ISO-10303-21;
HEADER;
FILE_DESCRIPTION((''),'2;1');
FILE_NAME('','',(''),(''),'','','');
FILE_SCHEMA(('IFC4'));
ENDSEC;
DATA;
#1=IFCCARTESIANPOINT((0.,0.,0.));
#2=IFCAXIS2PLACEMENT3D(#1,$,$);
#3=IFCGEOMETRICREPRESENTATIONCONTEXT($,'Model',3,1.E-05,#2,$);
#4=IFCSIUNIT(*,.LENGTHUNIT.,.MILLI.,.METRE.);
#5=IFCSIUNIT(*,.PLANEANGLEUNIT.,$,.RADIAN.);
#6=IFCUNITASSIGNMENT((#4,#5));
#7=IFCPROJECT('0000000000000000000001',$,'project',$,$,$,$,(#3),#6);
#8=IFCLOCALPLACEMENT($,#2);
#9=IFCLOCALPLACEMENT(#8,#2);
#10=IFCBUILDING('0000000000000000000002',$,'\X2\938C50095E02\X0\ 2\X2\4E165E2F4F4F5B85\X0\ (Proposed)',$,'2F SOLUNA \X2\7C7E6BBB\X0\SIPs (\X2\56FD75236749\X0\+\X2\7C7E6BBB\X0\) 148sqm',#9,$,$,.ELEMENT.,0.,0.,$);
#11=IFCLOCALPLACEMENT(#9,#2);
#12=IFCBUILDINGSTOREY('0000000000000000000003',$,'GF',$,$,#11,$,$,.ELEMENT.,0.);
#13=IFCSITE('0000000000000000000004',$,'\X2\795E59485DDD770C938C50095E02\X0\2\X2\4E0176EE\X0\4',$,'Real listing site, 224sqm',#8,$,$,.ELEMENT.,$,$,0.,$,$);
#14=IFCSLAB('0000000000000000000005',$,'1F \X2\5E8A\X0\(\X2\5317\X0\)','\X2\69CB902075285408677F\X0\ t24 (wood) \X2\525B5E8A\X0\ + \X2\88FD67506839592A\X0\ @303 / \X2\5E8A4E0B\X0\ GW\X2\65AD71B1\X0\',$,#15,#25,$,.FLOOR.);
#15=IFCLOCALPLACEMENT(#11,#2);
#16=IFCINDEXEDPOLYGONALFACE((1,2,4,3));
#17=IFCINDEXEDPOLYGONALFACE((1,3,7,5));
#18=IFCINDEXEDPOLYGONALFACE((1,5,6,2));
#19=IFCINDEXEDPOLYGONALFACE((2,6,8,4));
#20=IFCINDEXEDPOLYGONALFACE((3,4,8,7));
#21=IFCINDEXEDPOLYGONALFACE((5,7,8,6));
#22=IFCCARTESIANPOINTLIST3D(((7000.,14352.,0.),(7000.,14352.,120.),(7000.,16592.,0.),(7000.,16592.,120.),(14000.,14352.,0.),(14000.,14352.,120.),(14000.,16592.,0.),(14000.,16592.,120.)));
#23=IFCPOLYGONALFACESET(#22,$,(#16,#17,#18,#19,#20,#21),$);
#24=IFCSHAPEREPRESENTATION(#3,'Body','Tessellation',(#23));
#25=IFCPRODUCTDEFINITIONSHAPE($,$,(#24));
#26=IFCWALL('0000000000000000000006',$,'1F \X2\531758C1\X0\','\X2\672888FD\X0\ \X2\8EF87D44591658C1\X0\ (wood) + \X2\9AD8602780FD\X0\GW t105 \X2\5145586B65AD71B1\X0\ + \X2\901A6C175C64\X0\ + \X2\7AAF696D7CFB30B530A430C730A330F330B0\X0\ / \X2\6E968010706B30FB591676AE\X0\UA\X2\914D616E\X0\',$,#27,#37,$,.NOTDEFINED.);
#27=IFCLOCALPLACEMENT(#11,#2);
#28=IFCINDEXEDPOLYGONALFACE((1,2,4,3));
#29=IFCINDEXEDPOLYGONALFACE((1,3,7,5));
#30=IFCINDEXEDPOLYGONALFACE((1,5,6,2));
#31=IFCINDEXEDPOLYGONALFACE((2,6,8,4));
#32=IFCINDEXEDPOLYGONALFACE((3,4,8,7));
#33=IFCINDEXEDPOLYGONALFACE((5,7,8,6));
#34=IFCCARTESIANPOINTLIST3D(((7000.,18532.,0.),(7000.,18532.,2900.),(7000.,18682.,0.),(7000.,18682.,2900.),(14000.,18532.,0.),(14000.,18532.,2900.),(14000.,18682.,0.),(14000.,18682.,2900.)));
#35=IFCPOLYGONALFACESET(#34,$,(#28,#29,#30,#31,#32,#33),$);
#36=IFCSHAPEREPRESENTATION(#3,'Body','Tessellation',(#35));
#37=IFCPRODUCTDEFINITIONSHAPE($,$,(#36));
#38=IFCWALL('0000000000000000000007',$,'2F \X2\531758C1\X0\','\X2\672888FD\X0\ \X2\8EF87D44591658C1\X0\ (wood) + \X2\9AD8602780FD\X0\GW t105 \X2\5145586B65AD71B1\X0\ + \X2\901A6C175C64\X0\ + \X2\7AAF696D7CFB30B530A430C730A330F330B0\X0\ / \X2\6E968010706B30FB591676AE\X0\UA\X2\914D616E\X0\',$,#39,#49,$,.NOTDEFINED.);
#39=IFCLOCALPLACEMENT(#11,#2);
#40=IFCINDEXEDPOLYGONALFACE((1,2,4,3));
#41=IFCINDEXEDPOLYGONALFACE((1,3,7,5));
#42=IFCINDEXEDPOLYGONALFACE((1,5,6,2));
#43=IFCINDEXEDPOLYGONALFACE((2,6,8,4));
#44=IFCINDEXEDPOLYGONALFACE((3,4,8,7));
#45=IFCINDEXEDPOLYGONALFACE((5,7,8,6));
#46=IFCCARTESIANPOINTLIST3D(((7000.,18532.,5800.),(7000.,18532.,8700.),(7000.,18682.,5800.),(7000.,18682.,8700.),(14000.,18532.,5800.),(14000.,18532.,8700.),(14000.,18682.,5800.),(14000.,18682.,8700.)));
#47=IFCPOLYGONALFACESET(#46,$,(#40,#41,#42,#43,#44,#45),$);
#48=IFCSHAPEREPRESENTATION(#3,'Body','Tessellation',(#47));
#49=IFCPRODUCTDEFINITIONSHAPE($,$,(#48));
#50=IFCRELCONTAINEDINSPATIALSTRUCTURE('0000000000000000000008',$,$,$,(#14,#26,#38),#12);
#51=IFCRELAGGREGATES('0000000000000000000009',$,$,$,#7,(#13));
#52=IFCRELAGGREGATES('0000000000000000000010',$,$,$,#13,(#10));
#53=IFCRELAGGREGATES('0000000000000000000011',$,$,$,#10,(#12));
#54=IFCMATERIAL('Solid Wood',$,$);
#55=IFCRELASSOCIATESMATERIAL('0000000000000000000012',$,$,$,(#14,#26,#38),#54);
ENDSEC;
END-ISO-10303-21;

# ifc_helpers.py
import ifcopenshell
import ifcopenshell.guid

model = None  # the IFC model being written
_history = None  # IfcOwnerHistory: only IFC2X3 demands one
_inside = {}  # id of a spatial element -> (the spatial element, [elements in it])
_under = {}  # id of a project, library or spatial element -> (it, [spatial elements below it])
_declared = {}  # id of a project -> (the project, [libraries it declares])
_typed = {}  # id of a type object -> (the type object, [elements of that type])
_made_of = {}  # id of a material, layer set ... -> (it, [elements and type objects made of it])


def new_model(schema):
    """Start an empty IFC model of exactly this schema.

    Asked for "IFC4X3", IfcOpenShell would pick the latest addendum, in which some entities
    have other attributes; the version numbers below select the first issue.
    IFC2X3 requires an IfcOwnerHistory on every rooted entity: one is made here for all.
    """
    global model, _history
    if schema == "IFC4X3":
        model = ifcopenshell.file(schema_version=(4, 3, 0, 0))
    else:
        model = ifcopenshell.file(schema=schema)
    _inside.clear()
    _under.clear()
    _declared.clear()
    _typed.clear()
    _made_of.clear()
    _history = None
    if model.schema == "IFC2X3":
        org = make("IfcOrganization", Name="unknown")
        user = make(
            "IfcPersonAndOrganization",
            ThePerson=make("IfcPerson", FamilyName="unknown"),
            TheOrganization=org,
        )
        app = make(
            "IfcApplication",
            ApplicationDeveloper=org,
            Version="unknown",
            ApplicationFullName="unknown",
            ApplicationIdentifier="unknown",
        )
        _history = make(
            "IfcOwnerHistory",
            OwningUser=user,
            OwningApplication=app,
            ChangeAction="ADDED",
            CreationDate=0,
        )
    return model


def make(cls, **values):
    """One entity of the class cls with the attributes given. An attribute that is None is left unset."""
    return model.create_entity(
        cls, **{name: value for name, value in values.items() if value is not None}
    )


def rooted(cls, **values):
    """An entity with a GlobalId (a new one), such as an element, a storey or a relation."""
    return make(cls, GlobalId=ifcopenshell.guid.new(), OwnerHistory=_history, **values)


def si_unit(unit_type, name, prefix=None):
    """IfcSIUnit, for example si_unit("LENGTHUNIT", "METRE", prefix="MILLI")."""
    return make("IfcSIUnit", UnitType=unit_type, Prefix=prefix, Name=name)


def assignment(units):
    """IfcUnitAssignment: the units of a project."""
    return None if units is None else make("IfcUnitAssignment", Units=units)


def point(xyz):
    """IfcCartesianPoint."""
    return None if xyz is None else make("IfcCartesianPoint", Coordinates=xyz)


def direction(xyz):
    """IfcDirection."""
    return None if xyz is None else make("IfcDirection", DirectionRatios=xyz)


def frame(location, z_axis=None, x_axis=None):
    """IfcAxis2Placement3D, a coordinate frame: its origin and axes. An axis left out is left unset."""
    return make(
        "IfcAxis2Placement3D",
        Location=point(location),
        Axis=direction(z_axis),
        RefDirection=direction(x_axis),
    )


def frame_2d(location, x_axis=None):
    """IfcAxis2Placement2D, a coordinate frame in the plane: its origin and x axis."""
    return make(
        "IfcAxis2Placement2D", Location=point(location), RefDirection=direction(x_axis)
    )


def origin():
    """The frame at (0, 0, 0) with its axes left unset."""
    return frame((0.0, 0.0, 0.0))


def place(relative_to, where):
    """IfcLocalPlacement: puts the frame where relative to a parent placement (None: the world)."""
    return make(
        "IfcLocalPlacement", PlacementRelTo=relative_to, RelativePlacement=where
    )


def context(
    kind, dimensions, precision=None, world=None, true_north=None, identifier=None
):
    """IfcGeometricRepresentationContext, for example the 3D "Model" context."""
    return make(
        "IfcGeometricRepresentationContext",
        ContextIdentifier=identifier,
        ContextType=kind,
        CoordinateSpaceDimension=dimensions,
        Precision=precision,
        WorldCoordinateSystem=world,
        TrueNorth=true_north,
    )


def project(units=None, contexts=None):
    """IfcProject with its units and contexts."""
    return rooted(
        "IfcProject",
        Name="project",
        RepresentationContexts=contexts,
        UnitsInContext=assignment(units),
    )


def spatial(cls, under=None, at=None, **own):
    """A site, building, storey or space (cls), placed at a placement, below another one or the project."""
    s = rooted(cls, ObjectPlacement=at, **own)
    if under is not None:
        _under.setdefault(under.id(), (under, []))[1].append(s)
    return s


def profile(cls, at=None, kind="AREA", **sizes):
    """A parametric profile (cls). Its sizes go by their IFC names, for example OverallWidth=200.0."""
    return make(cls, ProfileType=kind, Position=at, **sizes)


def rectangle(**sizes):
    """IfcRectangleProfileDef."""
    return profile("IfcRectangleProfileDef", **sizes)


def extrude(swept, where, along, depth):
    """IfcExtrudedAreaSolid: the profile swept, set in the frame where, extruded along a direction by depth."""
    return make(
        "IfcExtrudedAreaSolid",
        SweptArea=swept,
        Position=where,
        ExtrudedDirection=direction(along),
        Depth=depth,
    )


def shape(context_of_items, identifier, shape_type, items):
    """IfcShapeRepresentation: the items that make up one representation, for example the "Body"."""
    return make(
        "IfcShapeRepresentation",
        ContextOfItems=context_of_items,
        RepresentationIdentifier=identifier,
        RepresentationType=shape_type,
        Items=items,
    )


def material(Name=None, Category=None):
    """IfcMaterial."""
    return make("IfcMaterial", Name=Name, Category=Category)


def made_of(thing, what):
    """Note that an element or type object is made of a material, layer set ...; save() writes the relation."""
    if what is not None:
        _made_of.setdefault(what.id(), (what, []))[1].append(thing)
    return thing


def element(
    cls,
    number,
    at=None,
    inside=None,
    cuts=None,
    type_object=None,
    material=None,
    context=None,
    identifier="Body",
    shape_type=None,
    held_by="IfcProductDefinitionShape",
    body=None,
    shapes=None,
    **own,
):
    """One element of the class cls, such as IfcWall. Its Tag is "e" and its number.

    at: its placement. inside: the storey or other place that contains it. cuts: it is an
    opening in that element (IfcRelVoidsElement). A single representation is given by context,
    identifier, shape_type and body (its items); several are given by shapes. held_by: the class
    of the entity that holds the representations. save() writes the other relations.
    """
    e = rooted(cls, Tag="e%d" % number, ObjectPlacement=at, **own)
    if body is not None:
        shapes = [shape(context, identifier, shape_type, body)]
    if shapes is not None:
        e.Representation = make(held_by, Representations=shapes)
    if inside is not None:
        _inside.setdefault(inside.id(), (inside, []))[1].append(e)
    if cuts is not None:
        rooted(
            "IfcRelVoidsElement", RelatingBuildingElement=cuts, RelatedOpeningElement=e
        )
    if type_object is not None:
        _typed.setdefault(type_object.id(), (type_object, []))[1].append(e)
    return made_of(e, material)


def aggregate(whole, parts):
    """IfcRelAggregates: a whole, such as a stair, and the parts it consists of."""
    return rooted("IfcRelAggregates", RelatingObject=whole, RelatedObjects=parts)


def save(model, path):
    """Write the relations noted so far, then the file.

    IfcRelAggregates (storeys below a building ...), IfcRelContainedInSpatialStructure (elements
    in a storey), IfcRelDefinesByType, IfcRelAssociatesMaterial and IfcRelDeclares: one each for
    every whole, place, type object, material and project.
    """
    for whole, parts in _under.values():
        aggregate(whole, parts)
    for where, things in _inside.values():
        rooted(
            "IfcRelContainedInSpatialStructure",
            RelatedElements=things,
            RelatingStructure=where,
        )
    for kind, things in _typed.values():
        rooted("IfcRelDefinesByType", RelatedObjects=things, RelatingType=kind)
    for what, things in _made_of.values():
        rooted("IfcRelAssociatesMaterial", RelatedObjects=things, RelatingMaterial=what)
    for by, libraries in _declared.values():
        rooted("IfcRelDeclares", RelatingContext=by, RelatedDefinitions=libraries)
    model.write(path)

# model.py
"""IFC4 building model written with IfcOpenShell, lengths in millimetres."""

from ifc_helpers import new_model, si_unit, frame, frame_2d, origin, place, context, project, spatial, rectangle, extrude, material, element, save


model = new_model("IFC4")

# Units and contexts
model_context = context("Model", 3, precision=1e-05, world=origin())
ifc_project = project(units=[si_unit("LENGTHUNIT", "METRE", prefix="MILLI"), si_unit("PLANEANGLEUNIT", "RADIAN")], contexts=[model_context])

# Site, building, storey
site_placement = place(None, origin())
site = spatial("IfcSite", under=ifc_project, at=site_placement, Name="神奈川県鎌倉市2丁目4", ObjectType="Real listing site, 224sqm", CompositionType="ELEMENT", RefElevation=0.0)
building_placement = place(site_placement, origin())
building = spatial("IfcBuilding", under=site, at=building_placement, Name="鎌倉市 2世帯住宅 (Proposed)", ObjectType="2F SOLUNA 籾殻SIPs (国産杉+籾殻) 148sqm", CompositionType="ELEMENT", ElevationOfRefHeight=0.0, ElevationOfTerrain=0.0)
storey_placement = place(building_placement, origin())
storey = spatial("IfcBuildingStorey", under=building, at=storey_placement, Name="GF", CompositionType="ELEMENT", Elevation=0.0)

# Slab
ifc_material_1 = material(Name="Solid Wood")
slab_1_placement = place(storey_placement, frame((3500.0, 7176.0, 0.0)))
element("IfcSlab", 1, at=slab_1_placement, inside=storey, material=ifc_material_1, Name="1F 床(北)", Description="構造用合板 t24 (wood) 剛床 + 製材根太 @303 / 床下 GW断熱", PredefinedType="FLOOR", context=model_context, shape_type="SweptSolid", body=[
    extrude(rectangle(XDim=7000.0, YDim=2240.0, at=frame_2d((3500.0, 1120.0))), frame((3500.0, 7176.0, 0.0)), (0.0, 0.0, 1.0), 120.0),
])

# Wall
wall_1_placement = place(storey_placement, frame((3500.0, 9266.0, 0.0)))
element("IfcWall", 2, at=wall_1_placement, inside=storey, material=ifc_material_1, Name="1F 北壁", Description="木製 軸組外壁 (wood) + 高性能GW t105 充填断熱 + 通気層 + 窯業系サイディング / 準耐火・外皮UA配慮", PredefinedType="NOTDEFINED", context=model_context, shape_type="SweptSolid", body=[
    extrude(rectangle(XDim=7000.0, YDim=150.0, at=frame_2d((3500.0, 75.0))), frame((3500.0, 9266.0, 0.0)), (0.0, 0.0, 1.0), 2900.0),
])

# Wall
wall_2_placement = place(storey_placement, frame((3500.0, 9266.0, 2900.0)))
element("IfcWall", 3, at=wall_2_placement, inside=storey, material=ifc_material_1, Name="2F 北壁", Description="木製 軸組外壁 (wood) + 高性能GW t105 充填断熱 + 通気層 + 窯業系サイディング / 準耐火・外皮UA配慮", PredefinedType="NOTDEFINED", context=model_context, shape_type="SweptSolid", body=[
    extrude(rectangle(XDim=7000.0, YDim=150.0, at=frame_2d((3500.0, 75.0))), frame((3500.0, 9266.0, 2900.0)), (0.0, 0.0, 1.0), 2900.0),
])

save(model, "model.ifc")
